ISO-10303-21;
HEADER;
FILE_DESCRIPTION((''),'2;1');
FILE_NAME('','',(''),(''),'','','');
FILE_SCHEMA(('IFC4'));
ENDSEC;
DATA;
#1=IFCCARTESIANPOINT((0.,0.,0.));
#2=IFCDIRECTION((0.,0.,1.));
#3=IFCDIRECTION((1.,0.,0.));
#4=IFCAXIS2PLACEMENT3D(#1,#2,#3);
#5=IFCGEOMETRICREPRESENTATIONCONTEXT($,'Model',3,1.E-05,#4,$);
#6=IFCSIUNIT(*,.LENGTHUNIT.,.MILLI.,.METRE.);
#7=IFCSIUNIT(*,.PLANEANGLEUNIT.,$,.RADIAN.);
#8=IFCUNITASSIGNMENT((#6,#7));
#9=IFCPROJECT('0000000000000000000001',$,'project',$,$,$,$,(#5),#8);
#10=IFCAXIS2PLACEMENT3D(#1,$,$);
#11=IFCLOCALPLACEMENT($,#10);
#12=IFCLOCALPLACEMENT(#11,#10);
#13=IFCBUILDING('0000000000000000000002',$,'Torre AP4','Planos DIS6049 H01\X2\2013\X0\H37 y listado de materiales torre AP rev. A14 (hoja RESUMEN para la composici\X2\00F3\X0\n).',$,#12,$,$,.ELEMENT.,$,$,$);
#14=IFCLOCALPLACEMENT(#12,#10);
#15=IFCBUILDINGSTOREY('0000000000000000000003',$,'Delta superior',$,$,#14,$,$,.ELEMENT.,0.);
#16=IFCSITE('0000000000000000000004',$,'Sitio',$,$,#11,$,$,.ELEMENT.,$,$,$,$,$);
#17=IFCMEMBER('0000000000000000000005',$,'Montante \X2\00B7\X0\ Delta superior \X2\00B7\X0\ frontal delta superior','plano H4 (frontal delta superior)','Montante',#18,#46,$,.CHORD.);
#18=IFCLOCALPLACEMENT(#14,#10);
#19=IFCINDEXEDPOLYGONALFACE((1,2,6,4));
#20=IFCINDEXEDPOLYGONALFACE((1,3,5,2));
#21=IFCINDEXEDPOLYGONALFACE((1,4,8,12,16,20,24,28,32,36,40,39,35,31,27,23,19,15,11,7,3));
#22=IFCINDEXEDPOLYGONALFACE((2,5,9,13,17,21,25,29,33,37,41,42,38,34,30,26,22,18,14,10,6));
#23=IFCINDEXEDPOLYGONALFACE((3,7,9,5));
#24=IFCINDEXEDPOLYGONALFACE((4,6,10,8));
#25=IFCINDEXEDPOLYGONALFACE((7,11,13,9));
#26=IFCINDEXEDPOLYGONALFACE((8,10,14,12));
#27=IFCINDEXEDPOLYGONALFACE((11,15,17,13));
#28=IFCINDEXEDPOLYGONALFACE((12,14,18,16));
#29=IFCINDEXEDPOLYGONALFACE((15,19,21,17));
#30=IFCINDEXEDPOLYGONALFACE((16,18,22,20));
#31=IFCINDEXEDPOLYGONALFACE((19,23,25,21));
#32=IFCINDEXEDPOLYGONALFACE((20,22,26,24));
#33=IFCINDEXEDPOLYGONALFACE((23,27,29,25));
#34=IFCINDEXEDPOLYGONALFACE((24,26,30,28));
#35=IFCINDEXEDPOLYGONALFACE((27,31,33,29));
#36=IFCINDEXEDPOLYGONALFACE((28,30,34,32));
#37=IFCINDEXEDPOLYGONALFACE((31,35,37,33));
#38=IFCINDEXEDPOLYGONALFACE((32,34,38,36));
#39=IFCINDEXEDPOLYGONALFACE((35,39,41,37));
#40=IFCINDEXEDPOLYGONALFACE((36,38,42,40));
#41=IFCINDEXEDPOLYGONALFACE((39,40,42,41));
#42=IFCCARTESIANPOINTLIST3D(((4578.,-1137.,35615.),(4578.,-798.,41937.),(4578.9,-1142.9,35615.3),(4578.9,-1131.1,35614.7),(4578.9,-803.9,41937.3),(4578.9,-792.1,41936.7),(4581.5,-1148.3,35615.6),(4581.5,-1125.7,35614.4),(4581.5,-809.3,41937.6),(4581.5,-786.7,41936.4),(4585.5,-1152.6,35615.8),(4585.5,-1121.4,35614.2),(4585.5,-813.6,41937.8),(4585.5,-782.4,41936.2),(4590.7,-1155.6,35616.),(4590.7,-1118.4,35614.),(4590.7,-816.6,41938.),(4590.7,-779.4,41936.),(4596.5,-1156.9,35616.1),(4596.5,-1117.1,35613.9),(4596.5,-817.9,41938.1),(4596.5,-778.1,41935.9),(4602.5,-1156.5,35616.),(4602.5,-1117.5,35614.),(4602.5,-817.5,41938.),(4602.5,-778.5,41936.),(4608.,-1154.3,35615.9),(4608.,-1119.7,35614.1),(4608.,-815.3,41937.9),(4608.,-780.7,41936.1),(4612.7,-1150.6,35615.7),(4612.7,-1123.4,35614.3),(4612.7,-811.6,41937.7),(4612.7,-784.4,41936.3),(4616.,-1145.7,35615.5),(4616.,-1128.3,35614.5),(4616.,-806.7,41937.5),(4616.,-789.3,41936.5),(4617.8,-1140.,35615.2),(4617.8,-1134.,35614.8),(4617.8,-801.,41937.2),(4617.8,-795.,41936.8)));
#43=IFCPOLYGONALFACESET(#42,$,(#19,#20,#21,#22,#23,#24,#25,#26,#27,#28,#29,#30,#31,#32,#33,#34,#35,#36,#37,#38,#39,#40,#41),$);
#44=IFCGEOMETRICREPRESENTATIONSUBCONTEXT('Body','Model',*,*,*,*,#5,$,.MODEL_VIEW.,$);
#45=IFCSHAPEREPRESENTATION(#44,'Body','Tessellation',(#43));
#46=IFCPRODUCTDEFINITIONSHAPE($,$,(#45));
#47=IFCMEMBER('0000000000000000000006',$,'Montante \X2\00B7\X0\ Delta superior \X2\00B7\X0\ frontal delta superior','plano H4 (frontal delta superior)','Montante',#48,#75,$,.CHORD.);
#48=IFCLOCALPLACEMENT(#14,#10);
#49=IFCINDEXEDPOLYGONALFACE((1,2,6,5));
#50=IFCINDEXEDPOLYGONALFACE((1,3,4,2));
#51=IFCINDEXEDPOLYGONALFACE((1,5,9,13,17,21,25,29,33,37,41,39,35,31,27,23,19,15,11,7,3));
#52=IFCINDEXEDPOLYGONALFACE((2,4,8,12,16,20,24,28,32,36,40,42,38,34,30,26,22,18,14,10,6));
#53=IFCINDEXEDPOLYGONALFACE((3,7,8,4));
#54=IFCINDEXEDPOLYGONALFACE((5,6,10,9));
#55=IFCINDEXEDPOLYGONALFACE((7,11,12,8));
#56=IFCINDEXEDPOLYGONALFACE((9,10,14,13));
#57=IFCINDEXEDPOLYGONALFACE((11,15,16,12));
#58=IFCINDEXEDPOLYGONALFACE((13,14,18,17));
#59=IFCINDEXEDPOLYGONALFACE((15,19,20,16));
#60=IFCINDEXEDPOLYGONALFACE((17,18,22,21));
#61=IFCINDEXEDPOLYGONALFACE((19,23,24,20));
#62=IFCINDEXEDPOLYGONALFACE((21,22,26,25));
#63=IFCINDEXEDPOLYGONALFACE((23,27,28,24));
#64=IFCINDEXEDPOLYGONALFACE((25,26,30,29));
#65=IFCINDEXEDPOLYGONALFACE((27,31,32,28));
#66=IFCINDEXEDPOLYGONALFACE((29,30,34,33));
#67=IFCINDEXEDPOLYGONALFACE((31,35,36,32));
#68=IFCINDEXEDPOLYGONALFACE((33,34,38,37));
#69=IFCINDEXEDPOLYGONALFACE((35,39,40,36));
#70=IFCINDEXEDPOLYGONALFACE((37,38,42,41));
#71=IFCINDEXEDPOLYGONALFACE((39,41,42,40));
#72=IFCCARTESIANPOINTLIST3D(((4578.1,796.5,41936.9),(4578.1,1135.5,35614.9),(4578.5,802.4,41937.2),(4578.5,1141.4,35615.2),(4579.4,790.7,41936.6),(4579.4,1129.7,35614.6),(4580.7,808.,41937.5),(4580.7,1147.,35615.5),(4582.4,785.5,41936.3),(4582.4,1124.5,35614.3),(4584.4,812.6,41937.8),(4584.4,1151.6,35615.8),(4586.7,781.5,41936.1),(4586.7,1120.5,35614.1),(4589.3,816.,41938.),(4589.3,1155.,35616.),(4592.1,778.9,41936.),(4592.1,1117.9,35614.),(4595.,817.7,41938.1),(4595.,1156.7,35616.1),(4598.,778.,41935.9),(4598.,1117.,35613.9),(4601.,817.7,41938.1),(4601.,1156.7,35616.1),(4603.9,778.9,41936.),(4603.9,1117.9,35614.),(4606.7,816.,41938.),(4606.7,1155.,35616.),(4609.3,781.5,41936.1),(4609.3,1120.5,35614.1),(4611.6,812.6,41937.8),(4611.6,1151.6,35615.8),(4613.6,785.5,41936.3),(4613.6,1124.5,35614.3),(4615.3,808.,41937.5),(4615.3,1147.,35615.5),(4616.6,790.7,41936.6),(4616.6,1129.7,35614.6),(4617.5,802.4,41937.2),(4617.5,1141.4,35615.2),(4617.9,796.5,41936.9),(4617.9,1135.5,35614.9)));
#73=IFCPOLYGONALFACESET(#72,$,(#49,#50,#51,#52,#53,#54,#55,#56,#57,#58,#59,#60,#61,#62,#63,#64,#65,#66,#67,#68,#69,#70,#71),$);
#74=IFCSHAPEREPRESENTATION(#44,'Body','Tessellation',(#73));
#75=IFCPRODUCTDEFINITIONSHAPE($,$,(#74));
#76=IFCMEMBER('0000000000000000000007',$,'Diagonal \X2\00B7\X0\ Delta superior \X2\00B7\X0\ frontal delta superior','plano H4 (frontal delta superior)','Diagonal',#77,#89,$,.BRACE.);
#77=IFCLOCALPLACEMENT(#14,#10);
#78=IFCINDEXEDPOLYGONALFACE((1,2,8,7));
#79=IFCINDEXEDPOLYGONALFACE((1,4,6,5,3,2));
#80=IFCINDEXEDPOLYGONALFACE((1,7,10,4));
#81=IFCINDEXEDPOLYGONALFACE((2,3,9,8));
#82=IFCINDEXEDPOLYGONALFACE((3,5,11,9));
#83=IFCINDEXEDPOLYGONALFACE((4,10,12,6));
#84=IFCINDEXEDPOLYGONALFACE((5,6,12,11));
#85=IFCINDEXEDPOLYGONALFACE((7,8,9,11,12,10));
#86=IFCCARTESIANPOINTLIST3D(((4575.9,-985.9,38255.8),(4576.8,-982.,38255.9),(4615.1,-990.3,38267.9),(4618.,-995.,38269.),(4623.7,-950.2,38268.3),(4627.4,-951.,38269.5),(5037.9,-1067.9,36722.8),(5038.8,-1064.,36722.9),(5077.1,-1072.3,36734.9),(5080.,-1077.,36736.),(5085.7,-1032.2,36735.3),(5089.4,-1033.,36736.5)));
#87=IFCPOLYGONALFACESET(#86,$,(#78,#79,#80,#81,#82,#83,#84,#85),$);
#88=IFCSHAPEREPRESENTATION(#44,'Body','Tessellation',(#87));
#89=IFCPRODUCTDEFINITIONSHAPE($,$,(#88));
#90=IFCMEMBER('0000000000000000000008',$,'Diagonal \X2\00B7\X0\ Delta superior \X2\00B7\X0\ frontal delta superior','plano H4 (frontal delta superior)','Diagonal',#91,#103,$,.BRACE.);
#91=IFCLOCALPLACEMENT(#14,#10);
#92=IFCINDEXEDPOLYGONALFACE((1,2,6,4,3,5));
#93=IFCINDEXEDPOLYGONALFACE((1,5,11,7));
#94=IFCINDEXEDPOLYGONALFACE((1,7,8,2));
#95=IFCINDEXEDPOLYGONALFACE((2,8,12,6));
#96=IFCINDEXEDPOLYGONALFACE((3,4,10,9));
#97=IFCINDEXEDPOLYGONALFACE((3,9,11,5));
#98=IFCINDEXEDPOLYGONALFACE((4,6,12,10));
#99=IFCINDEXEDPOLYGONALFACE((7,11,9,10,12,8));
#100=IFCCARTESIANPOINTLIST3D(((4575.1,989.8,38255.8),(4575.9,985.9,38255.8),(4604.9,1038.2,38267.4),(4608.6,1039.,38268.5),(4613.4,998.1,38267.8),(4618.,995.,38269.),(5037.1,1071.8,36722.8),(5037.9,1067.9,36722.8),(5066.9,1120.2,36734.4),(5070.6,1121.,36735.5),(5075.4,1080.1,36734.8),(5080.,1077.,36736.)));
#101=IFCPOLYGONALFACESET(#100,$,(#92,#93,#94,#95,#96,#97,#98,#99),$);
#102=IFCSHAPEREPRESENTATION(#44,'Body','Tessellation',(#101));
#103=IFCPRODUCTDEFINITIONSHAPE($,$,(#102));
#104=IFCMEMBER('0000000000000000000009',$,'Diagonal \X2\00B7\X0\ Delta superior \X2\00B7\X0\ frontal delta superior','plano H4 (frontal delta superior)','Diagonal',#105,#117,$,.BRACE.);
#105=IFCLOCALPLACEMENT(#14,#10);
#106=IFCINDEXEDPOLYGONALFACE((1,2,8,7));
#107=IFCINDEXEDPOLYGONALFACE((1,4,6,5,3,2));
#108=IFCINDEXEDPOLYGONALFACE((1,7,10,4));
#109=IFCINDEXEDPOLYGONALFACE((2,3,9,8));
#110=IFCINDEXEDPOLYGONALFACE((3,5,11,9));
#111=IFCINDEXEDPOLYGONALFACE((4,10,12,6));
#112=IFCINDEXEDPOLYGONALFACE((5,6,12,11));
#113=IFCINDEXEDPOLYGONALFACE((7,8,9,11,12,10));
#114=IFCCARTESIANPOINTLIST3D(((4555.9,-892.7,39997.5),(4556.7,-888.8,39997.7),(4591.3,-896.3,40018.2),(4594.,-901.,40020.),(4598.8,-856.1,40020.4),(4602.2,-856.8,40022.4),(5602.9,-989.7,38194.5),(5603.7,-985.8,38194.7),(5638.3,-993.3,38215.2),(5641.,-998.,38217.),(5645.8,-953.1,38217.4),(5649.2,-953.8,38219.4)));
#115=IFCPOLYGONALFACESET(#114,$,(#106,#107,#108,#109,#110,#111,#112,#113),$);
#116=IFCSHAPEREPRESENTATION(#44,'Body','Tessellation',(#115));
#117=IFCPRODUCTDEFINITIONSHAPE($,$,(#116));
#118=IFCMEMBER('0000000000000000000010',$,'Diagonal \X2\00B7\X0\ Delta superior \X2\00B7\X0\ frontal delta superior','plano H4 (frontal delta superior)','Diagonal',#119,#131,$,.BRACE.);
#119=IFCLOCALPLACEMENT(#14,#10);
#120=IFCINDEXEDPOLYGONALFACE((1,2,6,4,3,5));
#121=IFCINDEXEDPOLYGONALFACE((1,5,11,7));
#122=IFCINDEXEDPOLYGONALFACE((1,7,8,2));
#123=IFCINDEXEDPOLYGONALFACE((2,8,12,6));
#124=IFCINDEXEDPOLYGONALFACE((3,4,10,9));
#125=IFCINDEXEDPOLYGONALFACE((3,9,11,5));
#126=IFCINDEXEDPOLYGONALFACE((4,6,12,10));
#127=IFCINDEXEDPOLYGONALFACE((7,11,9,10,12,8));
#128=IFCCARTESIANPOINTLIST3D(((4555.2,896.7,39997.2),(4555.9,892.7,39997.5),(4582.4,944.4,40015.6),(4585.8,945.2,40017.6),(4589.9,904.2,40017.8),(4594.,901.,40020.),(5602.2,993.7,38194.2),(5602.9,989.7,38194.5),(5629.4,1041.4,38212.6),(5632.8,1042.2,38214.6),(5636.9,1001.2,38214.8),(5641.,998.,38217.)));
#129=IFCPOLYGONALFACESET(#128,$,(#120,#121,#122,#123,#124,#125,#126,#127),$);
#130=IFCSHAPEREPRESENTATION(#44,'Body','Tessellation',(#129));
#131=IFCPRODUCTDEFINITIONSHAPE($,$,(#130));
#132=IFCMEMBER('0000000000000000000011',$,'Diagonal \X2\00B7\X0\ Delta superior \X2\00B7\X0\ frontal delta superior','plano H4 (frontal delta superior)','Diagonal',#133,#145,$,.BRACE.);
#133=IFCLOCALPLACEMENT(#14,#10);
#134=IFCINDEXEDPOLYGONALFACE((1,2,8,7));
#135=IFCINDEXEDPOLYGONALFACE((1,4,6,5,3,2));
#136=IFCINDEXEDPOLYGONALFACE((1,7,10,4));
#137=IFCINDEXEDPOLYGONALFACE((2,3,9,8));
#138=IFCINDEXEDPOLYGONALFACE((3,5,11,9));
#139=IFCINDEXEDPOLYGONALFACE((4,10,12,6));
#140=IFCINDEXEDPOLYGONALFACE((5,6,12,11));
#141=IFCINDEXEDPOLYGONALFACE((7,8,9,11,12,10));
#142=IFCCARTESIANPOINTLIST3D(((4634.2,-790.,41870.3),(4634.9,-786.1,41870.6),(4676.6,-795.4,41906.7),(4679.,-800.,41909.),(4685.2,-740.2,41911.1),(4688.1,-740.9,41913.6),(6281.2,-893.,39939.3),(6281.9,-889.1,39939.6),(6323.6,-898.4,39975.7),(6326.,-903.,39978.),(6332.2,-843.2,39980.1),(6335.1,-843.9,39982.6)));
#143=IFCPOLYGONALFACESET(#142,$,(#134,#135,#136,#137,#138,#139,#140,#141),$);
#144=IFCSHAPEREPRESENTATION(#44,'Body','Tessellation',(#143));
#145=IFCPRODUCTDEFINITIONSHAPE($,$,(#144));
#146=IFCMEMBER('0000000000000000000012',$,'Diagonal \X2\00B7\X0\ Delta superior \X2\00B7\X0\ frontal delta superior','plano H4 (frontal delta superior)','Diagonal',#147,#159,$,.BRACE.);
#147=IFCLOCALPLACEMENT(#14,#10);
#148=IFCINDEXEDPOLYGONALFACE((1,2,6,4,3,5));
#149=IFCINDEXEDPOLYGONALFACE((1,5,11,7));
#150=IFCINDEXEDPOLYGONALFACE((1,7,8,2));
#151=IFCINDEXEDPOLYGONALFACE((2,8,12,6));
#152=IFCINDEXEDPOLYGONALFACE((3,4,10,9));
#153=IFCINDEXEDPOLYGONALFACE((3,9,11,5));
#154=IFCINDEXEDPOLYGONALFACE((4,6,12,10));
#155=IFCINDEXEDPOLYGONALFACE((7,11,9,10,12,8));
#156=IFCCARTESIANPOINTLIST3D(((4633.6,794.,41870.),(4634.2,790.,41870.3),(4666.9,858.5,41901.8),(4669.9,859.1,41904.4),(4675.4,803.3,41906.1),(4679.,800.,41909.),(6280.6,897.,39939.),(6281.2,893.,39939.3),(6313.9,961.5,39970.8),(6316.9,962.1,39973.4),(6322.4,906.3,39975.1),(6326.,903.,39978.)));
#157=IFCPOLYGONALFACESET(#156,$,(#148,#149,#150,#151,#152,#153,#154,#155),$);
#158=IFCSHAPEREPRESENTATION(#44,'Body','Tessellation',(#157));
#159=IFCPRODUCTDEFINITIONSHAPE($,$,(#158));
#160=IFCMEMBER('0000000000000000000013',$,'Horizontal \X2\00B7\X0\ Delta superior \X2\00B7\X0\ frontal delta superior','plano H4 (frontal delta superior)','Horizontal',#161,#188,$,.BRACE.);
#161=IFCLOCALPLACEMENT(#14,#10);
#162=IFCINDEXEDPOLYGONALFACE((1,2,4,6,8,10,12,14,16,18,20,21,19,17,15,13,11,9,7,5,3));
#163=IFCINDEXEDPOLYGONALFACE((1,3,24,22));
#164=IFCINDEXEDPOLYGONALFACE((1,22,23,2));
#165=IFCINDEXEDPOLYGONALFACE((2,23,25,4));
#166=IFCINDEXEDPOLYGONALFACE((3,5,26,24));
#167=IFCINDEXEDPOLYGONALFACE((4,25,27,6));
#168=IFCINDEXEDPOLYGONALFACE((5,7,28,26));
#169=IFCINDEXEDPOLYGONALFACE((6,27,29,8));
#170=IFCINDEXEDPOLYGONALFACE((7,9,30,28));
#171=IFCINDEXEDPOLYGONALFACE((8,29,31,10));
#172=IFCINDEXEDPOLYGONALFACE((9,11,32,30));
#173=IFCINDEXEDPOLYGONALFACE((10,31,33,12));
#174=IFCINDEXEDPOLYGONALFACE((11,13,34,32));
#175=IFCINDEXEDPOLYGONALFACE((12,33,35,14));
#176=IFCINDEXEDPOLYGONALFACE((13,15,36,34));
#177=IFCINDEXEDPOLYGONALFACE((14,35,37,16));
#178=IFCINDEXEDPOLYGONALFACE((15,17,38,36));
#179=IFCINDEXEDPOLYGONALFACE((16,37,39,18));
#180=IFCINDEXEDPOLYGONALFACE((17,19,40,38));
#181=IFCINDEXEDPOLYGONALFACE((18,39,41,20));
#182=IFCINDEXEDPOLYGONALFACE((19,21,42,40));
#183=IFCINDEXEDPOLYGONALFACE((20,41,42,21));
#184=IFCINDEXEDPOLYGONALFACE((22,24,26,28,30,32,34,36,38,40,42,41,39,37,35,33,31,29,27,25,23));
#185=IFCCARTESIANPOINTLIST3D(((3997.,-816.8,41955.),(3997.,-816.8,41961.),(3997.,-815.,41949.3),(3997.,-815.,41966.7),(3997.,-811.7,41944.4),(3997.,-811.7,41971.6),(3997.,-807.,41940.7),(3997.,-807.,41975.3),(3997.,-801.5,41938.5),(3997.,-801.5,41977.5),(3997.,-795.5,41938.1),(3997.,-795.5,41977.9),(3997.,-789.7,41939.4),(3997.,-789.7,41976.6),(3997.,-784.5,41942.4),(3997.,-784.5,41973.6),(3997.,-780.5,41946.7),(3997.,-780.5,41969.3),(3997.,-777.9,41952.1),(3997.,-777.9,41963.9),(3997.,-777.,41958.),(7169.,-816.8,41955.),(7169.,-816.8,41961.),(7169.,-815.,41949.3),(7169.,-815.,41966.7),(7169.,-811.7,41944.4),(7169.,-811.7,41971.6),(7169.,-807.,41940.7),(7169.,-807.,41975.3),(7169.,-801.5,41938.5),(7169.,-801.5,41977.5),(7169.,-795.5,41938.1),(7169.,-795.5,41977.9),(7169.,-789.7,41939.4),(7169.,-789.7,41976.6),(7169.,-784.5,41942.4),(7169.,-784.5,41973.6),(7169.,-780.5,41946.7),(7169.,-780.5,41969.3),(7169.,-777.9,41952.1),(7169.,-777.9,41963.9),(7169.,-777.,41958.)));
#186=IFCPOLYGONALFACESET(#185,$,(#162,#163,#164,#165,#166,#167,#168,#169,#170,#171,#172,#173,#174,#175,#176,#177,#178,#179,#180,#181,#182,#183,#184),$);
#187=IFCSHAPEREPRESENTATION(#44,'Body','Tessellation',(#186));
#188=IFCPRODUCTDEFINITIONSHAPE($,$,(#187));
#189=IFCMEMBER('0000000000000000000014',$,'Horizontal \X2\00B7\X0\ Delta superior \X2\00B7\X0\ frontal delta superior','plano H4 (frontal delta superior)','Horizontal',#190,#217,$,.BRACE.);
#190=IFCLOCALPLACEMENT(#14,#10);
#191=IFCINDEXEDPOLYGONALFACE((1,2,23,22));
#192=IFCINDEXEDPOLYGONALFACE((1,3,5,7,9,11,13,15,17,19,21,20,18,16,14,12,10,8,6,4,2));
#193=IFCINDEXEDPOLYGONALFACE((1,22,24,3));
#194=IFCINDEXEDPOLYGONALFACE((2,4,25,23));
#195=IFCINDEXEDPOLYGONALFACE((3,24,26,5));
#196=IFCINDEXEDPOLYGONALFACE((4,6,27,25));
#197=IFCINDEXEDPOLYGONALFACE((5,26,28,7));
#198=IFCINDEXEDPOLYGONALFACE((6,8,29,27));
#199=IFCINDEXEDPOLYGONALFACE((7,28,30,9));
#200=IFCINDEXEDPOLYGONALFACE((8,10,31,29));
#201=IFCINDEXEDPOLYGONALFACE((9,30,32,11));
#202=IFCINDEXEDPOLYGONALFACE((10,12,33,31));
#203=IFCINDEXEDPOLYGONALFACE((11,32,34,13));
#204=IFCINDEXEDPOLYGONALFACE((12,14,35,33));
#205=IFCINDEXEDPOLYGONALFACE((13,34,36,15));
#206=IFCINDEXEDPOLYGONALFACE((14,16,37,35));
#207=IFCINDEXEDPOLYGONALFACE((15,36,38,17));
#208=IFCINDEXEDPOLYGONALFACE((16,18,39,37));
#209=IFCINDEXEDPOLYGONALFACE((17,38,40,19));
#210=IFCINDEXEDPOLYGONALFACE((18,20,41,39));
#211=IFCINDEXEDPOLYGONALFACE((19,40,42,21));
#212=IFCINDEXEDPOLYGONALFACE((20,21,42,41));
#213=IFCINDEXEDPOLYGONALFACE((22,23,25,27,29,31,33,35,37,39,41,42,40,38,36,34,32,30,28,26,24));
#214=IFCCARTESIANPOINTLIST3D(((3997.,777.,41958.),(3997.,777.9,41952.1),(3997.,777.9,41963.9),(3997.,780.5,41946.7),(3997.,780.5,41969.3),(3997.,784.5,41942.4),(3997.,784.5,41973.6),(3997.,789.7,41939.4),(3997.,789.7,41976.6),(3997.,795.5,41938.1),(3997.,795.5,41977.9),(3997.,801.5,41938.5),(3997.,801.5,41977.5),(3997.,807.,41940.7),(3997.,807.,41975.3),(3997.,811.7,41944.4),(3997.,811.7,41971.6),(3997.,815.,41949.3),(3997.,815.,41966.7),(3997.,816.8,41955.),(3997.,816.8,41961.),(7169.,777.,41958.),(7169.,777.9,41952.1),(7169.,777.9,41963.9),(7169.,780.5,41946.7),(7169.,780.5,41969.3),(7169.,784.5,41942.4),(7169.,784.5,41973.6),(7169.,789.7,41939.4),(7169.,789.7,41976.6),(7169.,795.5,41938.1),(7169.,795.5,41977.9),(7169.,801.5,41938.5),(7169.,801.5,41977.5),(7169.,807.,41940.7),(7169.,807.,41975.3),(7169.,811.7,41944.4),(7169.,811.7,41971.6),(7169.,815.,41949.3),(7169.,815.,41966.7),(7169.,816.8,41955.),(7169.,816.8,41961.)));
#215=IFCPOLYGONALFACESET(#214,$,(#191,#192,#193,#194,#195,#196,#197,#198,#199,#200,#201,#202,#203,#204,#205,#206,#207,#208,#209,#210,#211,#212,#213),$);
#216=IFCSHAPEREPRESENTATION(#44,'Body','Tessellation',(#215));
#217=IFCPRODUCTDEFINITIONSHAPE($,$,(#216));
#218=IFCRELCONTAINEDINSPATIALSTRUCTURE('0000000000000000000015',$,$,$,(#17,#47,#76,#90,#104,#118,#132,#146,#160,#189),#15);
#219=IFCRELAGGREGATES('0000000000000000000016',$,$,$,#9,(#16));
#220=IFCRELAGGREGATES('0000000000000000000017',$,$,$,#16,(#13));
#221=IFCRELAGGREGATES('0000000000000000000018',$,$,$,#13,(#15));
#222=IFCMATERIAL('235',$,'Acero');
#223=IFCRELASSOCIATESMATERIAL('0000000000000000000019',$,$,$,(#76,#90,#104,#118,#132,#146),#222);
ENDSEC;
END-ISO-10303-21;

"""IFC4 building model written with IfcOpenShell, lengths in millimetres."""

from ifc_helpers import new_model, si_unit, frame, frame_2d, origin, origin_with_axes, place, context, subcontext, project, spatial, circle, l_section, extrude, material, element, save


model = new_model("IFC4")

# Units and contexts
model_context = context("Model", 3, precision=1e-05, world=origin_with_axes())
body_context = subcontext(model_context, "Body", "Model", "MODEL_VIEW")
ifc_project = project(units=[si_unit("LENGTHUNIT", "METRE", prefix="MILLI"), si_unit("PLANEANGLEUNIT", "RADIAN")], contexts=[model_context])

# Site, building, storey
site_placement = place(None, origin())
site = spatial("IfcSite", under=ifc_project, at=site_placement, Name="Sitio", CompositionType="ELEMENT")
building_placement = place(site_placement, origin())
building = spatial("IfcBuilding", under=site, at=building_placement, Name="Torre AP4", Description="Planos DIS6049 H01–H37 y listado de materiales torre AP rev. A14 (hoja RESUMEN para la composición).", CompositionType="ELEMENT")
storey_placement = place(building_placement, origin())
storey = spatial("IfcBuildingStorey", under=building, at=storey_placement, Name="Delta superior", CompositionType="ELEMENT", Elevation=0.0)

# Members
for number, where, z_axis, x_axis, name in (
    (1, (4598.0, -798.0, 41937.0), (0.0, -0.053545, -0.998565), (-1.0, 0.0, 0.0), "Montante · Delta superior · frontal delta superior"),
    (2, (4598.0, 798.0, 41937.0), (0.0, 0.053545, -0.998565), (0.0, -0.998565, -0.053545), "Montante · Delta superior · frontal delta superior"),
):
    element("IfcMember", number, at=place(storey_placement, frame(where, z_axis=z_axis, x_axis=x_axis)), inside=storey, Name=name, Description="plano H4 (frontal delta superior)", ObjectType="Montante", PredefinedType="CHORD", context=body_context, shape_type="SweptSolid", body=[
        extrude(circle(Radius=20.0), None, (0.0, 0.0, 1.0), 6331.1),
    ])
ifc_material_1 = material(Name="235", Category="Acero")
for number, where, z_axis, x_axis, name in (
    (3, (4618.0, -995.0, 38269.0), (0.288173, -0.051148, -0.956211), (-0.934509, 0.202848, -0.292483), "Diagonal · Delta superior · frontal delta superior"),
    (4, (4618.0, 995.0, 38269.0), (0.288173, 0.051148, -0.956211), (-0.934509, -0.202848, -0.292483), "Diagonal · Delta superior · frontal delta superior"),
):
    element("IfcMember", number, at=place(storey_placement, frame(where, z_axis=z_axis, x_axis=x_axis)), inside=storey, material=ifc_material_1, Name=name, Description="plano H4 (frontal delta superior)", ObjectType="Diagonal", PredefinedType="BRACE", context=body_context, shape_type="SweptSolid", body=[
        extrude(l_section(Depth=45.0, Width=45.0, Thickness=4.0, at=frame_2d((22.5, 22.5))), None, (0.0, 0.0, 1.0), 1603.2),
    ])
for number, where, z_axis, x_axis, name in (
    (5, (4594.0, -901.0, 40020.0), (0.501628, -0.046474, -0.863834), (-0.845685, 0.183933, -0.500984), "Diagonal · Delta superior · frontal delta superior"),
    (6, (4594.0, 901.0, 40020.0), (0.501628, 0.046474, -0.863834), (-0.845685, -0.183933, -0.500984), "Diagonal · Delta superior · frontal delta superior"),
):
    element("IfcMember", number, at=place(storey_placement, frame(where, z_axis=z_axis, x_axis=x_axis)), inside=storey, material=ifc_material_1, Name=name, Description="plano H4 (frontal delta superior)", ObjectType="Diagonal", PredefinedType="BRACE", context=body_context, shape_type="SweptSolid", body=[
        extrude(l_section(Depth=45.0, Width=45.0, Thickness=4.0, at=frame_2d((22.5, 22.5))), None, (0.0, 0.0, 1.0), 2087.2),
    ])
for number, where, z_axis, x_axis, name in (
    (7, (4679.0, -800.0, 41909.0), (0.648406, -0.04055, -0.760214), (-0.745871, 0.166153, -0.645035), "Diagonal · Delta superior · frontal delta superior"),
    (8, (4679.0, 800.0, 41909.0), (0.648406, 0.04055, -0.760214), (-0.745871, -0.166153, -0.645035), "Diagonal · Delta superior · frontal delta superior"),
):
    element("IfcMember", number, at=place(storey_placement, frame(where, z_axis=z_axis, x_axis=x_axis)), inside=storey, material=ifc_material_1, Name=name, Description="plano H4 (frontal delta superior)", ObjectType="Diagonal", PredefinedType="BRACE", context=body_context, shape_type="SweptSolid", body=[
        extrude(l_section(Depth=60.0, Width=60.0, Thickness=4.0, at=frame_2d((30.0, 30.0))), None, (0.0, 0.0, 1.0), 2540.1),
    ])
for number, where, z_axis, x_axis, name in (
    (9, (3997.0, -797.0, 41958.0), (1.0, 0.0, 0.0), (0.0, 1.0, 0.0), "Horizontal · Delta superior · frontal delta superior"),
    (10, (3997.0, 797.0, 41958.0), (1.0, 0.0, 0.0), (0.0, -1.0, 0.0), "Horizontal · Delta superior · frontal delta superior"),
):
    element("IfcMember", number, at=place(storey_placement, frame(where, z_axis=z_axis, x_axis=x_axis)), inside=storey, Name=name, Description="plano H4 (frontal delta superior)", ObjectType="Horizontal", PredefinedType="BRACE", context=body_context, shape_type="SweptSolid", body=[
        extrude(circle(Radius=20.0), None, (0.0, 0.0, 1.0), 3172.0),
    ])

save(model, "model.ifc")
